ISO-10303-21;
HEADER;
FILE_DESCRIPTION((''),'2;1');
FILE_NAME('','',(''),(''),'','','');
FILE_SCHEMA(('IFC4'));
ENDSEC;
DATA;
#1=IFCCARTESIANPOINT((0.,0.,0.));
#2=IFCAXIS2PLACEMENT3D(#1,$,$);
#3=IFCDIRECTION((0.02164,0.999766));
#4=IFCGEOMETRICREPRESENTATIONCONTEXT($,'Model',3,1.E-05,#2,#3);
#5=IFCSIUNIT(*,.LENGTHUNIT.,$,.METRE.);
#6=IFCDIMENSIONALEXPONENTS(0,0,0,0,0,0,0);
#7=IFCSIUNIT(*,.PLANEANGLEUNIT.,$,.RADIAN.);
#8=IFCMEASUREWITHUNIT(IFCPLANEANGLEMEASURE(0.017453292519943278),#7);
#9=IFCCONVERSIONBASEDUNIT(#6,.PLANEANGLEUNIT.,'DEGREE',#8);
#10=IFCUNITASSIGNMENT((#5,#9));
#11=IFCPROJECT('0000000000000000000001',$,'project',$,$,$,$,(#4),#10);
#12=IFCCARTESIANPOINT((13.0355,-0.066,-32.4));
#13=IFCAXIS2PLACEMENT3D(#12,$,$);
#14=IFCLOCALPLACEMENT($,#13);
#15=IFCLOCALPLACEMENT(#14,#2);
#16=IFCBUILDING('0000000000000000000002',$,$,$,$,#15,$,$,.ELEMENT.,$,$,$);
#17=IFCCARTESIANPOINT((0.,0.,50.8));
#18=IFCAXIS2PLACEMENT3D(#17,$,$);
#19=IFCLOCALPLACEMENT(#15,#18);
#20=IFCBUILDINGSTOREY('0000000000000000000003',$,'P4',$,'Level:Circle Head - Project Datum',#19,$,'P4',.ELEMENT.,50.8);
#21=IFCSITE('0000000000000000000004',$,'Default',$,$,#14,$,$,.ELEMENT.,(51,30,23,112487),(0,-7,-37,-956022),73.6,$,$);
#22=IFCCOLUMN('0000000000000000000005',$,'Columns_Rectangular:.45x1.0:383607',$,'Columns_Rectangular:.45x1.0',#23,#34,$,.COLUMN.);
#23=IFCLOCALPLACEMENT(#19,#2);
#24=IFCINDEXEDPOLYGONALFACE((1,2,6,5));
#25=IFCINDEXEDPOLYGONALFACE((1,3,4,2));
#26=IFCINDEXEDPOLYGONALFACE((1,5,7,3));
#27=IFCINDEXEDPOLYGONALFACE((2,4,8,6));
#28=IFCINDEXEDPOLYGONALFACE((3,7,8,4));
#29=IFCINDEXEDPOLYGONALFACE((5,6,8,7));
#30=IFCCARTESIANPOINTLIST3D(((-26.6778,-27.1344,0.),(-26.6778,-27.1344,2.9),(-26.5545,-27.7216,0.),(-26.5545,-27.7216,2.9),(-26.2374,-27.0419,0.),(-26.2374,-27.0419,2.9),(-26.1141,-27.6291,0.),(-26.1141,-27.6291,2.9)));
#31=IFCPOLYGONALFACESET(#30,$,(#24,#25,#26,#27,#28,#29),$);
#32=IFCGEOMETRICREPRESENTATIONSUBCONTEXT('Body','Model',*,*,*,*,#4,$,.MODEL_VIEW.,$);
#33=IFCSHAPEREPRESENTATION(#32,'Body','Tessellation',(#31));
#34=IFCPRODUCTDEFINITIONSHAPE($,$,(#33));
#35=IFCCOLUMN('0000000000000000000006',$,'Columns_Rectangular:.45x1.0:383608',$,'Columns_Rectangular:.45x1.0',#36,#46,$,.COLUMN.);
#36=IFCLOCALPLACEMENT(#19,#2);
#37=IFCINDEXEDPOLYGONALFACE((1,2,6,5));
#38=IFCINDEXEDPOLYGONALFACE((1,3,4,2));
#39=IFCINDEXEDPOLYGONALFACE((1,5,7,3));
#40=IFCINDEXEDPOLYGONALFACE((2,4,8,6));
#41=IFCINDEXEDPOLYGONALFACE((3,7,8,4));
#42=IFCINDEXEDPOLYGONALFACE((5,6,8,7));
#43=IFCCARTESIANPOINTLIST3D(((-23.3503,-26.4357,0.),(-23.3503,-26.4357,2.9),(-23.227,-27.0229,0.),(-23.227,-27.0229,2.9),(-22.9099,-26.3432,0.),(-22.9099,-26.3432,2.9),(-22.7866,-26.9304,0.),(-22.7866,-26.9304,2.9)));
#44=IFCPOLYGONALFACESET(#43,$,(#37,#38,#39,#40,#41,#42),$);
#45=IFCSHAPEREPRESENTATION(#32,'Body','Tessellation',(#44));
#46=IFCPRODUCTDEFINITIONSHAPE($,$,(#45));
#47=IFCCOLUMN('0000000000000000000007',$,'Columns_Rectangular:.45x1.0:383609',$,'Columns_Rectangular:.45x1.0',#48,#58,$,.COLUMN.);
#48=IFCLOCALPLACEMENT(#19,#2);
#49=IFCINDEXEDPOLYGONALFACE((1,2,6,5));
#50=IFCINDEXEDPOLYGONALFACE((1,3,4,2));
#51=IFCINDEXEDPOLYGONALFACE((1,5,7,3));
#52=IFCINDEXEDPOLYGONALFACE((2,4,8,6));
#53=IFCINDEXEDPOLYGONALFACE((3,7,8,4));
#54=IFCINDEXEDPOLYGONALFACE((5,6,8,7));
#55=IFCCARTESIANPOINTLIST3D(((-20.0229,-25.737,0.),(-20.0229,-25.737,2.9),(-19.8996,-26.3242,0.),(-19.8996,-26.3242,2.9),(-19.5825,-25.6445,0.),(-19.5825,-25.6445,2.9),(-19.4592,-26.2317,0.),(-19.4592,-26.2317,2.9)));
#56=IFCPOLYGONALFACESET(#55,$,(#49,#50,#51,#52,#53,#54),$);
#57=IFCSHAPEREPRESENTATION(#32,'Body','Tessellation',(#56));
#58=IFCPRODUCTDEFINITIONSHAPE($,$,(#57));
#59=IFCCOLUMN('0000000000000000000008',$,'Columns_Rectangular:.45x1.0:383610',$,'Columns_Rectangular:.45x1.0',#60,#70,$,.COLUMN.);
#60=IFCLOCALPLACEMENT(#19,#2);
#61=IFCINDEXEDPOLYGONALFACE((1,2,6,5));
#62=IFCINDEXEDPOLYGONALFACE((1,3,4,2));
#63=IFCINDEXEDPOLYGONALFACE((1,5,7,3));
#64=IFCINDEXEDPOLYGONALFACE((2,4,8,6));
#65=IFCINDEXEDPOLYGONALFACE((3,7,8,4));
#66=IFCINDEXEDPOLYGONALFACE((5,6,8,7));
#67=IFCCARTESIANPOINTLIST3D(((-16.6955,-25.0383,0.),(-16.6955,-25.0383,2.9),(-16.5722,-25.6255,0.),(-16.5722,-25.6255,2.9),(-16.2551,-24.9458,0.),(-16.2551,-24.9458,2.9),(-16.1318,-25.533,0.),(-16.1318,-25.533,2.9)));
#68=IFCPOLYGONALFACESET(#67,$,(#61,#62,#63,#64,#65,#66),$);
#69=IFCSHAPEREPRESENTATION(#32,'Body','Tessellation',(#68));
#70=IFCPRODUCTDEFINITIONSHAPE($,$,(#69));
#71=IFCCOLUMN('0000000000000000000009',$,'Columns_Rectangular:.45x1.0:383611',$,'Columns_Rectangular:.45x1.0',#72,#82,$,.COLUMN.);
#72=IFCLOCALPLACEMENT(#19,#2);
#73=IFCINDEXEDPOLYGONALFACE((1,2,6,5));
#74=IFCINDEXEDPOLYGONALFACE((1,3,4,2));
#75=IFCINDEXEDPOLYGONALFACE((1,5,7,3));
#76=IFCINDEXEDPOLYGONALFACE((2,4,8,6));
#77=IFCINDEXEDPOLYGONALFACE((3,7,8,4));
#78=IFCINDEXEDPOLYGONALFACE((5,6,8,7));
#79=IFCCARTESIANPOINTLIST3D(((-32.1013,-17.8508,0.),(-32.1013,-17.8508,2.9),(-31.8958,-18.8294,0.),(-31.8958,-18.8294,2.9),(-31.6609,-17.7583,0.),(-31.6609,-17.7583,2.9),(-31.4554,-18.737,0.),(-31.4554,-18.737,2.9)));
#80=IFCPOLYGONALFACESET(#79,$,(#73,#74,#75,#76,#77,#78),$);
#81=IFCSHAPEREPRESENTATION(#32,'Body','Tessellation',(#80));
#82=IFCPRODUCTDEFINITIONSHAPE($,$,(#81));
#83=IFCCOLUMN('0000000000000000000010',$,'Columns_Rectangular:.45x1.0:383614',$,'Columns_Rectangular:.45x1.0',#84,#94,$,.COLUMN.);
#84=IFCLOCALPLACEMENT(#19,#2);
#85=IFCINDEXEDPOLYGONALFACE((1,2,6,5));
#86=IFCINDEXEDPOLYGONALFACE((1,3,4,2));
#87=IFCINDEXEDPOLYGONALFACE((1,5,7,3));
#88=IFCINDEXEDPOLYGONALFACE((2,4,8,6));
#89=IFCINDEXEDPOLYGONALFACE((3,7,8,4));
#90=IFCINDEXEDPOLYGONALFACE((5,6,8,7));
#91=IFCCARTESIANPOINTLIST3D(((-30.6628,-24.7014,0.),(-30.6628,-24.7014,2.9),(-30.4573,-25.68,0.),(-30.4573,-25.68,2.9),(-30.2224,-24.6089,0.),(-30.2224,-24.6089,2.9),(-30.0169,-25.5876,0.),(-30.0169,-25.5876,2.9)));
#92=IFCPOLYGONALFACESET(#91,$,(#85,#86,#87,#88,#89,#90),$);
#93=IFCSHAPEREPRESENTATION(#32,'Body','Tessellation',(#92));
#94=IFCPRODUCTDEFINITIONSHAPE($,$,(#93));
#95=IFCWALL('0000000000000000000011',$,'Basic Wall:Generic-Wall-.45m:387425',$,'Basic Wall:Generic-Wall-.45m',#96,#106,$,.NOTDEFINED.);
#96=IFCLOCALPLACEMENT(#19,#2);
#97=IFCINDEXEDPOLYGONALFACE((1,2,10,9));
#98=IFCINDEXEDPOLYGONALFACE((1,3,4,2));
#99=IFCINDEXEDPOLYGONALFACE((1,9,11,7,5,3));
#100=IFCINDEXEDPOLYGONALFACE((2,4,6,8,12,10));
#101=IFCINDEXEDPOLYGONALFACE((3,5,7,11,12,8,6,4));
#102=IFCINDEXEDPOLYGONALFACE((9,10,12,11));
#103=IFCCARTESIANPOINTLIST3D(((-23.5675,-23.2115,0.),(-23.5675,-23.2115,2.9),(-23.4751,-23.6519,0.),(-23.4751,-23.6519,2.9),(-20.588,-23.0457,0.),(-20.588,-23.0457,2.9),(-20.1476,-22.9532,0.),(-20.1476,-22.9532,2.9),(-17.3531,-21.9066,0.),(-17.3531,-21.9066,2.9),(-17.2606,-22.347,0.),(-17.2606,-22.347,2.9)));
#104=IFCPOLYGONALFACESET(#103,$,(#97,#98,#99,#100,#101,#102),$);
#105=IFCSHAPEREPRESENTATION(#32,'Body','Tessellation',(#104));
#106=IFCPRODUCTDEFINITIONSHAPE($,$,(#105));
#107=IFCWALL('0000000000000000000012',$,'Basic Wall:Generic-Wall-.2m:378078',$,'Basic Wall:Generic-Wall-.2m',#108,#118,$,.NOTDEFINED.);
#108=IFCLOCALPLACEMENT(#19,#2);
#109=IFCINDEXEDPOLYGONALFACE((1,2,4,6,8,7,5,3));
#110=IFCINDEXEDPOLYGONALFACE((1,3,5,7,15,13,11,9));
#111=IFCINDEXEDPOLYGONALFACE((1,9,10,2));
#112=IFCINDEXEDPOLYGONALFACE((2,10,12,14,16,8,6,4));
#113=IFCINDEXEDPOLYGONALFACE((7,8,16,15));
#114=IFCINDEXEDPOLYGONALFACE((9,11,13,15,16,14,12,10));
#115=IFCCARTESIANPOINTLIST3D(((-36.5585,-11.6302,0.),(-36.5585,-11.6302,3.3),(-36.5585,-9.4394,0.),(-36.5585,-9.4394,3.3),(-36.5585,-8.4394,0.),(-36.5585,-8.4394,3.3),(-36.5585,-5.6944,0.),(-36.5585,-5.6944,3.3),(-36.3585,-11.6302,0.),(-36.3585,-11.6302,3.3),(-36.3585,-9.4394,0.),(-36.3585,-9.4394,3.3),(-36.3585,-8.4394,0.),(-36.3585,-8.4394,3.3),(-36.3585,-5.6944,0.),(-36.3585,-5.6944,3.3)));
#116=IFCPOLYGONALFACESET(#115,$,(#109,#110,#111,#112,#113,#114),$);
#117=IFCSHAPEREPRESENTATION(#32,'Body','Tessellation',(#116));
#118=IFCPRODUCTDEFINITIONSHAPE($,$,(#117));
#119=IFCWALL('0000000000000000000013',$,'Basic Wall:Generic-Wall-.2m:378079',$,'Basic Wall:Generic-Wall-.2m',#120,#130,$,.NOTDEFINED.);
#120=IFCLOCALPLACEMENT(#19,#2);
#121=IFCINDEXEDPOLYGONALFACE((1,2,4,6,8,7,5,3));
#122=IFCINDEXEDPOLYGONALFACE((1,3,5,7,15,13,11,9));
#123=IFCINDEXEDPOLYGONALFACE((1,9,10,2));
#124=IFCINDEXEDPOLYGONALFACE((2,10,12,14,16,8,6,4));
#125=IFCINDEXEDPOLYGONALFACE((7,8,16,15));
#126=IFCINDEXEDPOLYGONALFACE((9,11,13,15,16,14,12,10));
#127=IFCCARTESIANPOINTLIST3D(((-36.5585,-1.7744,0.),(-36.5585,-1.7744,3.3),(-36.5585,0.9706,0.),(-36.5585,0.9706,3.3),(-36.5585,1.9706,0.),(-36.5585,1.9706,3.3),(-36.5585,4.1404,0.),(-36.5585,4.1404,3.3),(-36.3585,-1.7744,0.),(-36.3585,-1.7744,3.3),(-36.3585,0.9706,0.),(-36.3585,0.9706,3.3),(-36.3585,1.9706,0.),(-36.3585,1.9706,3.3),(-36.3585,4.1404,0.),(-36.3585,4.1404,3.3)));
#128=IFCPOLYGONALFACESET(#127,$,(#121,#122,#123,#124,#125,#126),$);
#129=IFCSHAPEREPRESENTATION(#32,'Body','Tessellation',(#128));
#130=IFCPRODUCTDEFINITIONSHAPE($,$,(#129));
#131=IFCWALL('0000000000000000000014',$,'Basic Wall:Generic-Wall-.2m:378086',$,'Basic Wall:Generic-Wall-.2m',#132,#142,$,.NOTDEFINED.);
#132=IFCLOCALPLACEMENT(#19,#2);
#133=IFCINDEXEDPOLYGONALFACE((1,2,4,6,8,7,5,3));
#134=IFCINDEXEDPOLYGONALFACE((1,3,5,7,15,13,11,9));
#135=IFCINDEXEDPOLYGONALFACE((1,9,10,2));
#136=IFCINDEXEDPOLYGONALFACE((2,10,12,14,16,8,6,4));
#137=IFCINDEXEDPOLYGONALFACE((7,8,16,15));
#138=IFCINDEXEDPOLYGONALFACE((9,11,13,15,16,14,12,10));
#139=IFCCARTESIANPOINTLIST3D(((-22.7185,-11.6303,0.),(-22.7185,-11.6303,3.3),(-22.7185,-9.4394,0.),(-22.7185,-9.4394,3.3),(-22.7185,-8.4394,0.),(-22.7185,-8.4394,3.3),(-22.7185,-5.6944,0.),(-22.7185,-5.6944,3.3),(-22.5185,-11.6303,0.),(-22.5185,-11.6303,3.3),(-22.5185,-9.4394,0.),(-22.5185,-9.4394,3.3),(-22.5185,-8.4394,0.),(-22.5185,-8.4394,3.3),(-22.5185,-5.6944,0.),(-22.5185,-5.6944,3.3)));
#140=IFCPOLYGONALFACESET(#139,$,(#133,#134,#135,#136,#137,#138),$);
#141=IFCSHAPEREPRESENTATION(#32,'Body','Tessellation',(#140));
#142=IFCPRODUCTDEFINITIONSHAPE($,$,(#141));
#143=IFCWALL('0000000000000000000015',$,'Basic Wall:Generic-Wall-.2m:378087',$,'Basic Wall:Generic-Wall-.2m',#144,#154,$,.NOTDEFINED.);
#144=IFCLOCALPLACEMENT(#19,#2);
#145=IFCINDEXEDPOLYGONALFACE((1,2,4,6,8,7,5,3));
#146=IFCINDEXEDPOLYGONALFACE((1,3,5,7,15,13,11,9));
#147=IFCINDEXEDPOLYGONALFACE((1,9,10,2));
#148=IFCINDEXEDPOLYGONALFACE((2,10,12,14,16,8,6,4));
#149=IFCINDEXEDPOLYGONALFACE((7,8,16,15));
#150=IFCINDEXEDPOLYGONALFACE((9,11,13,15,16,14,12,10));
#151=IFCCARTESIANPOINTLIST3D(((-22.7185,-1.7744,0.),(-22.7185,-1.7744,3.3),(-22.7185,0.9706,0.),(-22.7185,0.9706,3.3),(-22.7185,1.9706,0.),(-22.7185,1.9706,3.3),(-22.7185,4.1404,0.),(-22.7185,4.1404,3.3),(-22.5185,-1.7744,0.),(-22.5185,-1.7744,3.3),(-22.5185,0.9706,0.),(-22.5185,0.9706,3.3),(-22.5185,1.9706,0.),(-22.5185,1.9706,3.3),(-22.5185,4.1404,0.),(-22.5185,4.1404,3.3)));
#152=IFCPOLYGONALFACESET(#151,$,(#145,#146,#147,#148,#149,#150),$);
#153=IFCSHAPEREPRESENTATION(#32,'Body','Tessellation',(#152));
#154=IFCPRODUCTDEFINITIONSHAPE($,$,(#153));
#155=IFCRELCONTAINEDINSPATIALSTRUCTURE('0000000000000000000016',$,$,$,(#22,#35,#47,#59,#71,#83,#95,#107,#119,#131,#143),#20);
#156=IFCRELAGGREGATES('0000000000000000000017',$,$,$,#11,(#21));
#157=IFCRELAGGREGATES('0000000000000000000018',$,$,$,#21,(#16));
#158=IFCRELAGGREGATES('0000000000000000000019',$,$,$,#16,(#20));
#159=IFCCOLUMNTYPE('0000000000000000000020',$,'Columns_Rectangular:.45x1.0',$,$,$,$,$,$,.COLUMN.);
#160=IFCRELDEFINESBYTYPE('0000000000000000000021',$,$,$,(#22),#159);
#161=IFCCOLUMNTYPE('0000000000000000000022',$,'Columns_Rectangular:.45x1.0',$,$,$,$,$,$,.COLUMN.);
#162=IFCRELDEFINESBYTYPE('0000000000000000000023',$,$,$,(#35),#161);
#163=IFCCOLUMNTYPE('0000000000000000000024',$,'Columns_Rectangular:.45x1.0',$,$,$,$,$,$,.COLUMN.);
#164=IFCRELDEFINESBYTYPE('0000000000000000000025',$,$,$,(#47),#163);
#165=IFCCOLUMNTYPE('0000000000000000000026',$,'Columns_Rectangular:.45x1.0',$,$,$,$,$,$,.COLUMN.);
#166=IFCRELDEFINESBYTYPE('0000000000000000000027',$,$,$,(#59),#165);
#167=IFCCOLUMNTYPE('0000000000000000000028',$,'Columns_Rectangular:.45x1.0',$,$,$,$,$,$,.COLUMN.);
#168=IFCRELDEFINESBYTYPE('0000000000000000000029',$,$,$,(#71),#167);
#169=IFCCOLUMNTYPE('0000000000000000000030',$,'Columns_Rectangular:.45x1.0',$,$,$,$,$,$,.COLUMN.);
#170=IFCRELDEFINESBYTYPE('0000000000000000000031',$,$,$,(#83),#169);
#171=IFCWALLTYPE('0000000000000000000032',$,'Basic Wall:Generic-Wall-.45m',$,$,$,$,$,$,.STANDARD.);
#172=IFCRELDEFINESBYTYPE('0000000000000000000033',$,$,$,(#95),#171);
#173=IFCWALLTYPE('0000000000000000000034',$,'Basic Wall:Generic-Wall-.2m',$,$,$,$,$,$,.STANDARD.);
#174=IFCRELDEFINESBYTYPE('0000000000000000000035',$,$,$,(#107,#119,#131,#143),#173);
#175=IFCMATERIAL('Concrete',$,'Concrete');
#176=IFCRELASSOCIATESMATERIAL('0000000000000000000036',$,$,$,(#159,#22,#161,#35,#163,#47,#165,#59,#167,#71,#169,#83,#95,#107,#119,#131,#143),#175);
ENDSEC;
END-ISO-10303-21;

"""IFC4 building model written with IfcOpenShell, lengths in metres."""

from ifc_helpers import new_model, entity, si_unit, converted_unit, direction, frame, origin, place, context, subcontext, project, spatial, indexed_curve, outline, extrude, source, transform, mapped, material, type_object, type_shapes, element, save


model = new_model("IFC4")

# Units and contexts
model_context = context("Model", 3, precision=1e-05, world=origin(), true_north=direction((0.02164, 0.999766)))
body_context = subcontext(model_context, "Body", "Model", "MODEL_VIEW")
ifc_project = project(units=[si_unit("LENGTHUNIT", "METRE"), converted_unit("PLANEANGLEUNIT", "DEGREE", entity("IfcPlaneAngleMeasure", 0.017453292519943278), si_unit("PLANEANGLEUNIT", "RADIAN"), dimensions=[0, 0, 0, 0, 0, 0, 0])], contexts=[model_context])

# Site, building, storey
site_placement = place(None, frame((13.0355, -0.066, -32.4)))
site = spatial("IfcSite", under=ifc_project, at=site_placement, Name="Default", CompositionType="ELEMENT", RefLatitude=(51, 30, 23, 112487), RefLongitude=(0, -7, -37, -956022), RefElevation=73.6)
building_placement = place(site_placement, origin())
building = spatial("IfcBuilding", under=site, at=building_placement, CompositionType="ELEMENT")
storey_placement = place(building_placement, frame((0.0, 0.0, 50.8)))
storey = spatial("IfcBuildingStorey", under=building, at=storey_placement, Name="P4", ObjectType="Level:Circle Head - Project Datum", LongName="P4", CompositionType="ELEMENT", Elevation=50.8)

# Columns
ifc_material = material(Name="Concrete", Category="Concrete")
column_type_1 = type_object("IfcColumnType", Name="Columns_Rectangular:.45x1.0", PredefinedType="COLUMN", material=ifc_material)
shared_shape_1 = source(origin(), body_context, "Body", "SweptSolid", [
    extrude(outline(indexed_curve([(-1.45, -0.3), (1.45, -0.3), (1.45, 0.3), (-1.45, 0.3), (-1.45, -0.3)], self_intersect=False)), frame((-26.6161, -27.428, 52.25), z_axis=(0.978657, 0.2055, 0.0), x_axis=(0.0, 0.0, 1.0)), (0.0, 0.0, 1.0), 0.45),
])
type_shapes(column_type_1, [shared_shape_1])
column_1_placement = place(storey_placement, frame((0.0, 0.0, -50.8)))
element("IfcColumn", 1, at=column_1_placement, inside=storey, type_object=column_type_1, material=ifc_material, Name="Columns_Rectangular:.45x1.0:383607", ObjectType="Columns_Rectangular:.45x1.0", PredefinedType="COLUMN", context=body_context, shape_type="MappedRepresentation", body=[
    mapped(shared_shape_1, transform((0.0, 0.0, 0.0), scale=1.0)),
])
column_type_2 = type_object("IfcColumnType", Name="Columns_Rectangular:.45x1.0", PredefinedType="COLUMN", material=ifc_material)
shared_shape_2 = source(origin(), body_context, "Body", "SweptSolid", [
    extrude(outline(indexed_curve([(-1.45, -0.3), (1.45, -0.3), (1.45, 0.3), (-1.45, 0.3), (-1.45, -0.3)], self_intersect=False)), frame((-23.2887, -26.7293, 52.25), z_axis=(0.978657, 0.2055, 0.0), x_axis=(0.0, 0.0, 1.0)), (0.0, 0.0, 1.0), 0.45),
])
type_shapes(column_type_2, [shared_shape_2])
column_2_placement = place(storey_placement, frame((0.0, 0.0, -50.8)))
element("IfcColumn", 2, at=column_2_placement, inside=storey, type_object=column_type_2, material=ifc_material, Name="Columns_Rectangular:.45x1.0:383608", ObjectType="Columns_Rectangular:.45x1.0", PredefinedType="COLUMN", context=body_context, shape_type="MappedRepresentation", body=[
    mapped(shared_shape_2, transform((0.0, 0.0, 0.0), scale=1.0)),
])
column_type_3 = type_object("IfcColumnType", Name="Columns_Rectangular:.45x1.0", PredefinedType="COLUMN", material=ifc_material)
shared_shape_3 = source(origin(), body_context, "Body", "SweptSolid", [
    extrude(outline(indexed_curve([(-1.45, -0.3), (1.45, -0.3), (1.45, 0.3), (-1.45, 0.3), (-1.45, -0.3)], self_intersect=False)), frame((-19.9612, -26.0306, 52.25), z_axis=(0.978657, 0.2055, 0.0), x_axis=(0.0, 0.0, 1.0)), (0.0, 0.0, 1.0), 0.45),
])
type_shapes(column_type_3, [shared_shape_3])
column_3_placement = place(storey_placement, frame((0.0, 0.0, -50.8)))
element("IfcColumn", 3, at=column_3_placement, inside=storey, type_object=column_type_3, material=ifc_material, Name="Columns_Rectangular:.45x1.0:383609", ObjectType="Columns_Rectangular:.45x1.0", PredefinedType="COLUMN", context=body_context, shape_type="MappedRepresentation", body=[
    mapped(shared_shape_3, transform((0.0, 0.0, 0.0), scale=1.0)),
])
column_type_4 = type_object("IfcColumnType", Name="Columns_Rectangular:.45x1.0", PredefinedType="COLUMN", material=ifc_material)
shared_shape_4 = source(origin(), body_context, "Body", "SweptSolid", [
    extrude(outline(indexed_curve([(-1.45, -0.3), (1.45, -0.3), (1.45, 0.3), (-1.45, 0.3), (-1.45, -0.3)], self_intersect=False)), frame((-16.6338, -25.3319, 52.25), z_axis=(0.978657, 0.2055, 0.0), x_axis=(0.0, 0.0, 1.0)), (0.0, 0.0, 1.0), 0.45),
])
type_shapes(column_type_4, [shared_shape_4])
column_4_placement = place(storey_placement, frame((0.0, 0.0, -50.8)))
element("IfcColumn", 4, at=column_4_placement, inside=storey, type_object=column_type_4, material=ifc_material, Name="Columns_Rectangular:.45x1.0:383610", ObjectType="Columns_Rectangular:.45x1.0", PredefinedType="COLUMN", context=body_context, shape_type="MappedRepresentation", body=[
    mapped(shared_shape_4, transform((0.0, 0.0, 0.0), scale=1.0)),
])
column_type_5 = type_object("IfcColumnType", Name="Columns_Rectangular:.45x1.0", PredefinedType="COLUMN", material=ifc_material)
shared_shape_5 = source(origin(), body_context, "Body", "SweptSolid", [
    extrude(outline(indexed_curve([(-1.45, -0.225), (1.45, -0.225), (1.45, 0.225), (-1.45, 0.225), (-1.45, -0.225)], self_intersect=False)), frame((-31.6756, -18.7832, 52.25), z_axis=(-0.2055, 0.978657, 0.0), x_axis=(0.0, 0.0, 1.0)), (0.0, 0.0, 1.0), 1.0),
])
type_shapes(column_type_5, [shared_shape_5])
column_5_placement = place(storey_placement, frame((0.0, 0.0, -50.8)))
element("IfcColumn", 5, at=column_5_placement, inside=storey, type_object=column_type_5, material=ifc_material, Name="Columns_Rectangular:.45x1.0:383611", ObjectType="Columns_Rectangular:.45x1.0", PredefinedType="COLUMN", context=body_context, shape_type="MappedRepresentation", body=[
    mapped(shared_shape_5, transform((0.0, 0.0, 0.0), scale=1.0)),
])
column_type_6 = type_object("IfcColumnType", Name="Columns_Rectangular:.45x1.0", PredefinedType="COLUMN", material=ifc_material)
shared_shape_6 = source(origin(), body_context, "Body", "SweptSolid", [
    extrude(outline(indexed_curve([(-1.45, -0.225), (1.45, -0.225), (1.45, 0.225), (-1.45, 0.225), (-1.45, -0.225)], self_intersect=False)), frame((-30.2371, -25.6338, 52.25), z_axis=(-0.2055, 0.978657, 0.0), x_axis=(0.0, 0.0, 1.0)), (0.0, 0.0, 1.0), 1.0),
])
type_shapes(column_type_6, [shared_shape_6])
column_6_placement = place(storey_placement, frame((0.0, 0.0, -50.8)))
element("IfcColumn", 6, at=column_6_placement, inside=storey, type_object=column_type_6, material=ifc_material, Name="Columns_Rectangular:.45x1.0:383614", ObjectType="Columns_Rectangular:.45x1.0", PredefinedType="COLUMN", context=body_context, shape_type="MappedRepresentation", body=[
    mapped(shared_shape_6, transform((0.0, 0.0, 0.0), scale=1.0)),
])

# Walls
wall_type_1 = type_object("IfcWallType", Name="Basic Wall:Generic-Wall-.45m", PredefinedType="STANDARD")
wall_1_placement = place(storey_placement, frame((-23.5213, -23.4317, 0.0), z_axis=(0.0, 0.0, 1.0), x_axis=(0.978657, 0.2055, 0.0)))
element("IfcWall", 7, at=wall_1_placement, inside=storey, type_object=wall_type_1, material=ifc_material, Name="Basic Wall:Generic-Wall-.45m:387425", ObjectType="Basic Wall:Generic-Wall-.45m", PredefinedType="NOTDEFINED", context=body_context, shape_type="SweptSolid", body=[
    extrude(outline(indexed_curve([(6.35, -0.225), (6.35, 0.225), (0.0, 0.225), (0.0, -0.225), (2.95, -0.225), (3.4, -0.225), (6.35, -0.225)], self_intersect=False)), origin(), (0.0, 0.0, 1.0), 2.9),
])
wall_type_2 = type_object("IfcWallType", Name="Basic Wall:Generic-Wall-.2m", PredefinedType="STANDARD")
wall_2_placement = place(storey_placement, frame((-36.4585, -5.6944, 0.0), z_axis=(0.0, 0.0, 1.0), x_axis=(0.0, -1.0, 0.0)))
element("IfcWall", 8, at=wall_2_placement, inside=storey, type_object=wall_type_2, material=ifc_material, Name="Basic Wall:Generic-Wall-.2m:378078", ObjectType="Basic Wall:Generic-Wall-.2m", PredefinedType="NOTDEFINED", context=body_context, shape_type="SweptSolid", body=[
    extrude(outline(indexed_curve([(5.9357, -0.1), (5.9357, 0.1), (3.745, 0.1), (2.745, 0.1), (0.0, 0.1), (0.0, -0.1), (2.745, -0.1), (3.745, -0.1), (5.9357, -0.1)], self_intersect=False)), origin(), (0.0, 0.0, 1.0), 3.3),
])
wall_3_placement = place(storey_placement, frame((-36.4585, -1.7744, 0.0), z_axis=(0.0, 0.0, 1.0), x_axis=(0.0, 1.0, 0.0)))
element("IfcWall", 9, at=wall_3_placement, inside=storey, type_object=wall_type_2, material=ifc_material, Name="Basic Wall:Generic-Wall-.2m:378079", ObjectType="Basic Wall:Generic-Wall-.2m", PredefinedType="NOTDEFINED", context=body_context, shape_type="SweptSolid", body=[
    extrude(outline(indexed_curve([(5.9149, -0.1), (5.9149, 0.1), (3.745, 0.1), (2.745, 0.1), (0.0, 0.1), (0.0, -0.1), (2.745, -0.1), (3.745, -0.1), (5.9149, -0.1)], self_intersect=False)), origin(), (0.0, 0.0, 1.0), 3.3),
])
wall_4_placement = place(storey_placement, frame((-22.6185, -5.6944, 0.0), z_axis=(0.0, 0.0, 1.0), x_axis=(0.0, -1.0, 0.0)))
element("IfcWall", 10, at=wall_4_placement, inside=storey, type_object=wall_type_2, material=ifc_material, Name="Basic Wall:Generic-Wall-.2m:378086", ObjectType="Basic Wall:Generic-Wall-.2m", PredefinedType="NOTDEFINED", context=body_context, shape_type="SweptSolid", body=[
    extrude(outline(indexed_curve([(5.9358, -0.1), (5.9359, 0.1), (3.745, 0.1), (2.745, 0.1), (0.0, 0.1), (0.0, -0.1), (2.745, -0.1), (3.745, -0.1), (5.9358, -0.1)], self_intersect=False)), origin(), (0.0, 0.0, 1.0), 3.3),
])
wall_5_placement = place(storey_placement, frame((-22.6185, -1.7744, 0.0), z_axis=(0.0, 0.0, 1.0), x_axis=(0.0, 1.0, 0.0)))
element("IfcWall", 11, at=wall_5_placement, inside=storey, type_object=wall_type_2, material=ifc_material, Name="Basic Wall:Generic-Wall-.2m:378087", ObjectType="Basic Wall:Generic-Wall-.2m", PredefinedType="NOTDEFINED", context=body_context, shape_type="SweptSolid", body=[
    extrude(outline(indexed_curve([(5.9149, -0.1), (5.9149, 0.1), (3.745, 0.1), (2.745, 0.1), (0.0, 0.1), (0.0, -0.1), (2.745, -0.1), (3.745, -0.1), (5.9149, -0.1)], self_intersect=False)), origin(), (0.0, 0.0, 1.0), 3.3),
])

save(model, "model.ifc")
